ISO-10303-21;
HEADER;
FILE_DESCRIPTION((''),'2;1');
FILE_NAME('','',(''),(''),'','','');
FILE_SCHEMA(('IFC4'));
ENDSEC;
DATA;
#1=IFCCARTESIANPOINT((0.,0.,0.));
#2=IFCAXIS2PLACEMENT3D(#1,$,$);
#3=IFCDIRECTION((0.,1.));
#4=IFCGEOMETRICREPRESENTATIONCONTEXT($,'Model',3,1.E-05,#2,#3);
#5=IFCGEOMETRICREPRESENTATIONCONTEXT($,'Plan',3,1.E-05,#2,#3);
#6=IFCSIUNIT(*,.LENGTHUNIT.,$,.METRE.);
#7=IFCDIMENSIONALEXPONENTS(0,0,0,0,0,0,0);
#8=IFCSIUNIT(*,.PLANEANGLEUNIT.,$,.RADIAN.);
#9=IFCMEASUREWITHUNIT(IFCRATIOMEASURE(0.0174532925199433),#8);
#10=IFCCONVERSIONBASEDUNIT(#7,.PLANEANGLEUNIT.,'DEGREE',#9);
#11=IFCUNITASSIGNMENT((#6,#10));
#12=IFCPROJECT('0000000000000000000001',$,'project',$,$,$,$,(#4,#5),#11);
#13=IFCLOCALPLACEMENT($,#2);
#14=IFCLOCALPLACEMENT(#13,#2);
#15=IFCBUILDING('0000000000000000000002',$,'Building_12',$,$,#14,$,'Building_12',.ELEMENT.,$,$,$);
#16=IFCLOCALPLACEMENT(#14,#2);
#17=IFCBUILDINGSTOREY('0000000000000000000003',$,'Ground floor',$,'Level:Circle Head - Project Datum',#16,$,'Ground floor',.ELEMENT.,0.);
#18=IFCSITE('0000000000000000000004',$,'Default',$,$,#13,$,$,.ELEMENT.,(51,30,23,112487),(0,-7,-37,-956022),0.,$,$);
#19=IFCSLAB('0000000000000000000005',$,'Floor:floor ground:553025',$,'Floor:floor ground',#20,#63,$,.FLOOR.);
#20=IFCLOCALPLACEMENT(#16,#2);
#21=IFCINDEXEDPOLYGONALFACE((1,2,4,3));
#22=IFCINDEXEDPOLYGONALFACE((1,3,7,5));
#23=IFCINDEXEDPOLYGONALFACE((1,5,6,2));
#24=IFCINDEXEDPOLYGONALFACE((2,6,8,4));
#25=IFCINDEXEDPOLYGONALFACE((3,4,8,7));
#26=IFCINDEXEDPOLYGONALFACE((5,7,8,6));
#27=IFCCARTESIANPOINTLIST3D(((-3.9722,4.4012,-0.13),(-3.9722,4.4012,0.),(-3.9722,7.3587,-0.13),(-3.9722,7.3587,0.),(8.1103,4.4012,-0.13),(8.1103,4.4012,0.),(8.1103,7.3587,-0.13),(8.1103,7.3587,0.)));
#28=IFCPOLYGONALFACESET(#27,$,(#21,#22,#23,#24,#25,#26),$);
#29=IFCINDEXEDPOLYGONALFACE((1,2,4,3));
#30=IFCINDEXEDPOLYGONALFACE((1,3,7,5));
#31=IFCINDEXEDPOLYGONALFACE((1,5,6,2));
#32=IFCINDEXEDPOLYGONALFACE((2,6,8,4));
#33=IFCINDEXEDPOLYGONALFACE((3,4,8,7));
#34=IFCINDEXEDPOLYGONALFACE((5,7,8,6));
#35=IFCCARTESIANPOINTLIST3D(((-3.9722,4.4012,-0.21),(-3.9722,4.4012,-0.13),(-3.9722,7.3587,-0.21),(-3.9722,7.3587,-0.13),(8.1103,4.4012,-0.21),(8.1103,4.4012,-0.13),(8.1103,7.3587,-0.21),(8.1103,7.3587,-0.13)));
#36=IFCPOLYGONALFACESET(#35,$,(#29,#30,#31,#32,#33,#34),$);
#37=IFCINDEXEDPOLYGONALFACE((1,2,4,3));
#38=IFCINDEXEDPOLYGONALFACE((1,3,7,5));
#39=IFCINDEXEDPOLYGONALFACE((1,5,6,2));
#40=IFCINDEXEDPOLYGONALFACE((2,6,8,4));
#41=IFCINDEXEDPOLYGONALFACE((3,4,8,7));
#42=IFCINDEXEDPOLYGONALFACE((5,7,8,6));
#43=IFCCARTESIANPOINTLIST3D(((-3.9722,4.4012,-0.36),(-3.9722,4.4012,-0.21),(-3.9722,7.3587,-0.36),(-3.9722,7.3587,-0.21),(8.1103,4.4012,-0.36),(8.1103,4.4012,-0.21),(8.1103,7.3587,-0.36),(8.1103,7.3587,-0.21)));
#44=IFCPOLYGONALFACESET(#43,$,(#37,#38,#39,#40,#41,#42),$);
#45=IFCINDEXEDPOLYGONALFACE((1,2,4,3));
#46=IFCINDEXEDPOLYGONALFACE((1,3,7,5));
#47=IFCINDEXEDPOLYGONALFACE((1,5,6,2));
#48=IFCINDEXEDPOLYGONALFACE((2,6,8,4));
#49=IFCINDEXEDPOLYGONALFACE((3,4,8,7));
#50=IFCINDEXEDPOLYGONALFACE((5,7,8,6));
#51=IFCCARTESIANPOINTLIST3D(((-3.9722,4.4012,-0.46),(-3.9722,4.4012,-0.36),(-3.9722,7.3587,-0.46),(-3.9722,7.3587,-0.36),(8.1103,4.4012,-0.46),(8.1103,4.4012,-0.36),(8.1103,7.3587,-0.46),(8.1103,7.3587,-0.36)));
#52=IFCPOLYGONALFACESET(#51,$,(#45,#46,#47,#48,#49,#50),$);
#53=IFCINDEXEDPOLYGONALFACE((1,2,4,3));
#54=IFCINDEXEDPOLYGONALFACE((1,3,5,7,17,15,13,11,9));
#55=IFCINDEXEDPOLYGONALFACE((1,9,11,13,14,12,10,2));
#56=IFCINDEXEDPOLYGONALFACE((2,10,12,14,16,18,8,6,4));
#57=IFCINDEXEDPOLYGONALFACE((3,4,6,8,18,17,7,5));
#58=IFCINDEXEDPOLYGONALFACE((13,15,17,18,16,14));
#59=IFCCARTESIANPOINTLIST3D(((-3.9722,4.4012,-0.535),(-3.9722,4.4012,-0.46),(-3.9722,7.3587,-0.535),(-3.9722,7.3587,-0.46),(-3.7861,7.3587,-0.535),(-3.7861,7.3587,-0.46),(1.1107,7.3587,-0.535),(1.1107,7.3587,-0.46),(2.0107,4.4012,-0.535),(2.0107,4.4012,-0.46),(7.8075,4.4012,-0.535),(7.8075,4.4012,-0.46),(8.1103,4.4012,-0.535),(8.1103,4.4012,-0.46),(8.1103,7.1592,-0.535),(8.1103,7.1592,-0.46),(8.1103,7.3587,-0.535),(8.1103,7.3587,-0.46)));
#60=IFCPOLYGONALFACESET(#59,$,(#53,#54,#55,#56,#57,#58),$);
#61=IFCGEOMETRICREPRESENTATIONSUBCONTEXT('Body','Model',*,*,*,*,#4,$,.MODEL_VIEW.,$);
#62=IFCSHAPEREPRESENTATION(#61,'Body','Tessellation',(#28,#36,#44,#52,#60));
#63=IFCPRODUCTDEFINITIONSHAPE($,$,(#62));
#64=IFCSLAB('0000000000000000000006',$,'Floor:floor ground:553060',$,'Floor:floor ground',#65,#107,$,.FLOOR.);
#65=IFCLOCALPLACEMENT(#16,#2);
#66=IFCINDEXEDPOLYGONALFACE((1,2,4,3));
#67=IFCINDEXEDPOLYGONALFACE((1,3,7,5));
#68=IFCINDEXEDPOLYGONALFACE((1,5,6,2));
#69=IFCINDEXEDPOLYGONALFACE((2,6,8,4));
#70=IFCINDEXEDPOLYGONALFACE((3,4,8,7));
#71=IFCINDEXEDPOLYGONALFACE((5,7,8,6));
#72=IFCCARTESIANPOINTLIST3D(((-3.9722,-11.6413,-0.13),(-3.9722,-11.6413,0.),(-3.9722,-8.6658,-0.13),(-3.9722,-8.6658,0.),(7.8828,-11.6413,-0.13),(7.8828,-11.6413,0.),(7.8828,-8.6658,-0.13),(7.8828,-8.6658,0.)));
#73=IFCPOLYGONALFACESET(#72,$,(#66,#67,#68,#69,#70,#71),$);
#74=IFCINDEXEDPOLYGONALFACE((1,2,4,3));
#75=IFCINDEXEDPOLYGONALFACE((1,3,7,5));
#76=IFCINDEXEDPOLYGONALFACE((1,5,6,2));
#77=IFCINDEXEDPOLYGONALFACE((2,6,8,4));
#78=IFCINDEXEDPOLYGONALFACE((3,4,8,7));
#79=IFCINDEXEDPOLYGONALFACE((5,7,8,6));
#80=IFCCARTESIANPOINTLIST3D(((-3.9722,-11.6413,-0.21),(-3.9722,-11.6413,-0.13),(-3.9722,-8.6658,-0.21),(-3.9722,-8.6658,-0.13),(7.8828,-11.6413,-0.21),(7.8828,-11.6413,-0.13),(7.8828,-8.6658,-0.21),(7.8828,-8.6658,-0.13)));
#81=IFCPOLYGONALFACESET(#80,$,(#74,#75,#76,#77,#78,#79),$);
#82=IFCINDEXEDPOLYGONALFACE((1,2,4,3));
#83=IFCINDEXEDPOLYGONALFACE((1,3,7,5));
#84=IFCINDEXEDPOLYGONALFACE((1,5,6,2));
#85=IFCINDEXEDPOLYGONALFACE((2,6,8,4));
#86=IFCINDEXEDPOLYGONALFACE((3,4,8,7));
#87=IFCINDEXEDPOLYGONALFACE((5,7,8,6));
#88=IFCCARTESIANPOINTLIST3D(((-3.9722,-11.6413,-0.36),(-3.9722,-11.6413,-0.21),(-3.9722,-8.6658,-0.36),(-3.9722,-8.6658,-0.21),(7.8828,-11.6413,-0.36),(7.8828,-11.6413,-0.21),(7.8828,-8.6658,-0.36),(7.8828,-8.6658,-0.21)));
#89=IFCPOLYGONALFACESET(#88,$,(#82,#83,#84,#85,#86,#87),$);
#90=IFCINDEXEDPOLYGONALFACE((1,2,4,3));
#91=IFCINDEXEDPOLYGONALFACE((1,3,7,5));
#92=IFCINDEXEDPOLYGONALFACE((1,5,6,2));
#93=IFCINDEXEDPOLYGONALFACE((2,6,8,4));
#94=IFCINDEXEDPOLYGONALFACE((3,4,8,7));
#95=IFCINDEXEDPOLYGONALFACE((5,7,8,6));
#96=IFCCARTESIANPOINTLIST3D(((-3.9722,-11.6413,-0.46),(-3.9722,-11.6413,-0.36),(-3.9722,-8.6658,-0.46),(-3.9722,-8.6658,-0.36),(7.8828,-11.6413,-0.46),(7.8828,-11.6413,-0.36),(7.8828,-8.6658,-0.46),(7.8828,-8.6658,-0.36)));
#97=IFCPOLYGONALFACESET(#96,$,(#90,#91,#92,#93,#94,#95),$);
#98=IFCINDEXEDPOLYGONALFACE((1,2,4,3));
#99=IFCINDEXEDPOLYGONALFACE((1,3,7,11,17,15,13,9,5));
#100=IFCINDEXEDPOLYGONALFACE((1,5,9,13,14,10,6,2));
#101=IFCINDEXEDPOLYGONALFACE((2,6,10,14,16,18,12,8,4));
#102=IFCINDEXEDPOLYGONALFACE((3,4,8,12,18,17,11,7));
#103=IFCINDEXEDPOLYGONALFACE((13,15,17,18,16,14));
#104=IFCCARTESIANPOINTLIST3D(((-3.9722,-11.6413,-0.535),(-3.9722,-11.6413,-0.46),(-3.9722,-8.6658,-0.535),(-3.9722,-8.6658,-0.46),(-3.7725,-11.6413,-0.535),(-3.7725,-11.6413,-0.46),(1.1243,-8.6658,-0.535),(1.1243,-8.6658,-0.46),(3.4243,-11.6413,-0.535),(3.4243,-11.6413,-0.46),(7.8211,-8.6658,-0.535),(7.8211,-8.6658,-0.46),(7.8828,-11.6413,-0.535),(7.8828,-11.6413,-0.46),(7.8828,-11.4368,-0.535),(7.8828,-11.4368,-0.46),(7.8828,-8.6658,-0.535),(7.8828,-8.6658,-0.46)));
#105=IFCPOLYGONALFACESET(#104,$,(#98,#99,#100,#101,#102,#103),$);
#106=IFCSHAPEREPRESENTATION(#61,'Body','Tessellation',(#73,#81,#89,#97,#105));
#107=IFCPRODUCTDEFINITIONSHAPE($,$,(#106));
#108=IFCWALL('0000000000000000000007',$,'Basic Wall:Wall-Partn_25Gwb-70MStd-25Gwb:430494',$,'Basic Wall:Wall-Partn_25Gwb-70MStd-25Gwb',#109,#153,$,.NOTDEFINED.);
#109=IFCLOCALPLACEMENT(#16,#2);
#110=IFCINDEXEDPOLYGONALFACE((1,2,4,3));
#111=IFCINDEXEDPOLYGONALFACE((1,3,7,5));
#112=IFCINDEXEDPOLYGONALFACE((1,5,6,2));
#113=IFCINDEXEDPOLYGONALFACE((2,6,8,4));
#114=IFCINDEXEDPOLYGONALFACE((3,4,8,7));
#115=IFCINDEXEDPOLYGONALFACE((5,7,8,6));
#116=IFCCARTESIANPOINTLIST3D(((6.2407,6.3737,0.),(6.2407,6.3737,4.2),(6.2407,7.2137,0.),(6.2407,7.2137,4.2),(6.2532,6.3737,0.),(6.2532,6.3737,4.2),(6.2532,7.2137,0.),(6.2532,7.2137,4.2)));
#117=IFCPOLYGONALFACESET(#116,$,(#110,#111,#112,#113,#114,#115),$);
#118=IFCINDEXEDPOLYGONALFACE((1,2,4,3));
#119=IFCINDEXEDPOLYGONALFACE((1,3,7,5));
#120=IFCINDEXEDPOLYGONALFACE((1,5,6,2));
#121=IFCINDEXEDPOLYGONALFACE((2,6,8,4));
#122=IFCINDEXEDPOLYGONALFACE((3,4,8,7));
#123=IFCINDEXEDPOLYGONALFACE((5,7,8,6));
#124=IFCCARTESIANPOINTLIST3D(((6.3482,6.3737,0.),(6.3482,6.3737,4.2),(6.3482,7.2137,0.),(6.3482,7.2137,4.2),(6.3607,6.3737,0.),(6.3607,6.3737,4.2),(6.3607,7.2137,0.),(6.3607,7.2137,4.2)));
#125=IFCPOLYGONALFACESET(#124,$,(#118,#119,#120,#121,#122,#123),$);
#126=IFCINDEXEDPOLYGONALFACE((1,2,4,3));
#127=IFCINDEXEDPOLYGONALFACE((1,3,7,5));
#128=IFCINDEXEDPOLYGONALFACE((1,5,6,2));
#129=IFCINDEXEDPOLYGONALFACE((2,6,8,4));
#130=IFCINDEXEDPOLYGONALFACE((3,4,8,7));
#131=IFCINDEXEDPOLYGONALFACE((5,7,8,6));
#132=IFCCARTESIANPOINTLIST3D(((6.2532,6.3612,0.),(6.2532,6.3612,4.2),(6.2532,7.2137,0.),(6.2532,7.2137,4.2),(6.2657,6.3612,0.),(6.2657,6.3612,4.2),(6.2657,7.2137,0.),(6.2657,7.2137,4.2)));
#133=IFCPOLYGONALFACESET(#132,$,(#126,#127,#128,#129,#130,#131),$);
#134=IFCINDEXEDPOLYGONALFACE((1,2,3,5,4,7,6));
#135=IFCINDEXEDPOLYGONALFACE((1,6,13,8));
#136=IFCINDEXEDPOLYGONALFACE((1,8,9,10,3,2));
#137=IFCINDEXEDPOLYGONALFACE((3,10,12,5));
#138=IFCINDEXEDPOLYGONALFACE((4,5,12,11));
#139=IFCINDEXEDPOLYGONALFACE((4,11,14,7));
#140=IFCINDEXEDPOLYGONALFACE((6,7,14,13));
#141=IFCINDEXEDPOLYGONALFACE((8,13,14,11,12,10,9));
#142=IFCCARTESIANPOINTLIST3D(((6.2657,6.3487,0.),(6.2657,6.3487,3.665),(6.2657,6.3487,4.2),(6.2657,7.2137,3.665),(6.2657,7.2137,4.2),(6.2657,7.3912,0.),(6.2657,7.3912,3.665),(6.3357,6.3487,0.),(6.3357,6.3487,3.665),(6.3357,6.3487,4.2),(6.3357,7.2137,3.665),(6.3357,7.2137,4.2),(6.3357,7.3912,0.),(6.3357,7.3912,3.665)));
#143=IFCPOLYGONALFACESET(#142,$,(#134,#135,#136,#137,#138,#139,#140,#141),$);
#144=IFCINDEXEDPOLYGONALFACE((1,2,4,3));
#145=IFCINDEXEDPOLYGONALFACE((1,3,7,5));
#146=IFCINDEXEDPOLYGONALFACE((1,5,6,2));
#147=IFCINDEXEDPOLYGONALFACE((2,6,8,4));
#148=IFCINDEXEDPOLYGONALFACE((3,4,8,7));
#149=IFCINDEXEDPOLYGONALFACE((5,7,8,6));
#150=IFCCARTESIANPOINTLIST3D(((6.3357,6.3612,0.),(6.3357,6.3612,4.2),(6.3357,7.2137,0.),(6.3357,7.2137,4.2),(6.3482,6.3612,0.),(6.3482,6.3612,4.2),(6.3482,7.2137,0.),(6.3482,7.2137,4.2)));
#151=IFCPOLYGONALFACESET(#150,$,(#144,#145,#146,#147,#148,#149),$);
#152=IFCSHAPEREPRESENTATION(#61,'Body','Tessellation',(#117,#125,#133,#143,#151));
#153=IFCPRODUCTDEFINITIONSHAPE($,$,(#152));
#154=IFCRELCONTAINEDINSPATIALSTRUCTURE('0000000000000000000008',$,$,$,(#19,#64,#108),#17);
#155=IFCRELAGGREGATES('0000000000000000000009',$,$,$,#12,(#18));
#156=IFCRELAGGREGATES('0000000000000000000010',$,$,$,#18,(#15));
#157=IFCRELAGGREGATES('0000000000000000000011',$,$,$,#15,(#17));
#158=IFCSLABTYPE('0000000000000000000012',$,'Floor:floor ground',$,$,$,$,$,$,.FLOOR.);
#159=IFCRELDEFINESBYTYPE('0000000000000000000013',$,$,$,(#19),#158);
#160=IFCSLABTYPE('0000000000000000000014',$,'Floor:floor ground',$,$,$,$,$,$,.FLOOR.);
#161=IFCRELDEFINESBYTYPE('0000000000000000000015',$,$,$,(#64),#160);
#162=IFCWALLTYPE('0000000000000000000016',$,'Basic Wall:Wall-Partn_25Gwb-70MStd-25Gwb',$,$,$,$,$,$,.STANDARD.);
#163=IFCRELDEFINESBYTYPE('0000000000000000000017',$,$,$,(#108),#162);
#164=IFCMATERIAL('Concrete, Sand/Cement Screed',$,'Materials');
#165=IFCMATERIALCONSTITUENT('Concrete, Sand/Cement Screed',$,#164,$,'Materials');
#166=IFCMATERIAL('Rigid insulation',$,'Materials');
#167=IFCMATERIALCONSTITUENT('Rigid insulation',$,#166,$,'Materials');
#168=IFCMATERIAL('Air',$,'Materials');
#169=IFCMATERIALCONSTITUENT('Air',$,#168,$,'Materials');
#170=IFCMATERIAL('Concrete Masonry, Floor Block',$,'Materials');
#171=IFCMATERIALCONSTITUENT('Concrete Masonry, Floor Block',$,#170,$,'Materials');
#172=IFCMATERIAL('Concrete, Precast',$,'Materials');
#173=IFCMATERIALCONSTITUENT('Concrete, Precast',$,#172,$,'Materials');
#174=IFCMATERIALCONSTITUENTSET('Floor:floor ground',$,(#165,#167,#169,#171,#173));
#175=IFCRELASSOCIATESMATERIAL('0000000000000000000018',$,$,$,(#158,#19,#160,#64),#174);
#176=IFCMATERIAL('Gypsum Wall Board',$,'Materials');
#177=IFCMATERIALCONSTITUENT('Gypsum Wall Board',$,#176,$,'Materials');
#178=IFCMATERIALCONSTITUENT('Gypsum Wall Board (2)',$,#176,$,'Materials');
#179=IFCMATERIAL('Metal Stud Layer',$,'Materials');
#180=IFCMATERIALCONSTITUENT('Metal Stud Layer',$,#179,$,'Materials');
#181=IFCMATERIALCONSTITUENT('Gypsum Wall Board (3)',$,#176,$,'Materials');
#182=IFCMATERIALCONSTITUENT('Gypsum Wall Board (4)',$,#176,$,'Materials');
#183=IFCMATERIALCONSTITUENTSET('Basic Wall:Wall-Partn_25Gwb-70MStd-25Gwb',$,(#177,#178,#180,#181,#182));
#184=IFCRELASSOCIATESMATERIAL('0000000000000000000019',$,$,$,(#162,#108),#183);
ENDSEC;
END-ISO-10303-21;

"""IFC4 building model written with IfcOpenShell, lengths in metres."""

from ifc_helpers import new_model, entity, si_unit, converted_unit, direction, frame, origin, place, context, subcontext, project, spatial, indexed_curve, outline, extrude, material, constituent, constituent_set, type_object, element, save


model = new_model("IFC4")

# Units and contexts
model_context = context("Model", 3, precision=1e-05, world=origin(), true_north=direction((0.0, 1.0)))
plan_context = context("Plan", 3, precision=1e-05, world=origin(), true_north=direction((0.0, 1.0)))
body_context = subcontext(model_context, "Body", "Model", "MODEL_VIEW")
ifc_project = project(units=[si_unit("LENGTHUNIT", "METRE"), converted_unit("PLANEANGLEUNIT", "DEGREE", entity("IfcRatioMeasure", 0.0174532925199433), si_unit("PLANEANGLEUNIT", "RADIAN"), dimensions=[0, 0, 0, 0, 0, 0, 0])], contexts=[model_context, plan_context])

# Site, building, storey
site_placement = place(None, origin())
site = spatial("IfcSite", under=ifc_project, at=site_placement, Name="Default", CompositionType="ELEMENT", RefLatitude=(51, 30, 23, 112487), RefLongitude=(0, -7, -37, -956022), RefElevation=0.0)
building_placement = place(site_placement, origin())
building = spatial("IfcBuilding", under=site, at=building_placement, Name="Building_12", LongName="Building_12", CompositionType="ELEMENT")
storey_placement = place(building_placement, origin())
storey = spatial("IfcBuildingStorey", under=building, at=storey_placement, Name="Ground floor", ObjectType="Level:Circle Head - Project Datum", LongName="Ground floor", CompositionType="ELEMENT", Elevation=0.0)

# Slabs
ifc_material_1 = material(Name="Concrete, Sand/Cement Screed", Category="Materials")
ifc_constituent_1 = constituent(ifc_material_1, Name="Concrete, Sand/Cement Screed", Category="Materials")
ifc_material_2 = material(Name="Rigid insulation", Category="Materials")
ifc_constituent_2 = constituent(ifc_material_2, Name="Rigid insulation", Category="Materials")
ifc_material_3 = material(Name="Air", Category="Materials")
ifc_constituent_3 = constituent(ifc_material_3, Name="Air", Category="Materials")
ifc_material_4 = material(Name="Concrete Masonry, Floor Block", Category="Materials")
ifc_constituent_4 = constituent(ifc_material_4, Name="Concrete Masonry, Floor Block", Category="Materials")
ifc_material_5 = material(Name="Concrete, Precast", Category="Materials")
ifc_constituent_5 = constituent(ifc_material_5, Name="Concrete, Precast", Category="Materials")
ifc_constituent_set_1 = constituent_set(constituents=[ifc_constituent_1, ifc_constituent_2, ifc_constituent_3, ifc_constituent_4, ifc_constituent_5], Name="Floor:floor ground")
slab_type_1 = type_object("IfcSlabType", Name="Floor:floor ground", PredefinedType="FLOOR", material=ifc_constituent_set_1)
slab_1_placement = place(storey_placement, origin())
element("IfcSlab", 1, at=slab_1_placement, inside=storey, type_object=slab_type_1, material=ifc_constituent_set_1, Name="Floor:floor ground:553025", ObjectType="Floor:floor ground", PredefinedType="FLOOR", context=body_context, shape_type="SweptSolid", body=[
    extrude(outline(indexed_curve([(-1.4787, -6.0412), (1.4787, -6.0412), (1.4787, 6.0412), (-1.4787, 6.0412), (-1.4787, -6.0412)], self_intersect=False)), frame((2.0691, 5.8799, -0.13), z_axis=(0.0, 0.0, 1.0), x_axis=(0.0, -1.0, 0.0)), (0.0, 0.0, 1.0), 0.13),
    extrude(outline(indexed_curve([(-1.4787, -6.0412), (1.4787, -6.0412), (1.4787, 6.0412), (-1.4787, 6.0412), (-1.4787, -6.0412)], self_intersect=False)), frame((2.0691, 5.8799, -0.21), z_axis=(0.0, 0.0, 1.0), x_axis=(0.0, -1.0, 0.0)), (0.0, 0.0, 1.0), 0.08),
    extrude(outline(indexed_curve([(-1.4787, -6.0412), (1.4787, -6.0412), (1.4787, 6.0412), (-1.4787, 6.0412), (-1.4787, -6.0412)], self_intersect=False)), frame((2.0691, 5.8799, -0.36), z_axis=(0.0, 0.0, 1.0), x_axis=(0.0, -1.0, 0.0)), (0.0, 0.0, 1.0), 0.15),
    extrude(outline(indexed_curve([(-1.4787, -6.0412), (1.4787, -6.0412), (1.4787, 6.0412), (-1.4787, 6.0412), (-1.4787, -6.0412)], self_intersect=False)), frame((2.0691, 5.8799, -0.46), z_axis=(0.0, 0.0, 1.0), x_axis=(0.0, -1.0, 0.0)), (0.0, 0.0, 1.0), 0.1),
    extrude(outline(indexed_curve([(-1.3366, -6.5866), (1.6209, -6.5866), (1.6209, -0.6037), (1.6209, 5.1931), (1.6209, 5.4959), (-1.1371, 5.4959), (-1.3366, 5.4959), (-1.3366, -1.5037), (-1.3366, -6.4005), (-1.3366, -6.5866)], self_intersect=False)), frame((2.6144, 6.0221, -0.535), z_axis=(0.0, 0.0, 1.0), x_axis=(0.0, -1.0, 0.0)), (0.0, 0.0, 1.0), 0.075),
])
slab_type_2 = type_object("IfcSlabType", Name="Floor:floor ground", PredefinedType="FLOOR", material=ifc_constituent_set_1)
slab_2_placement = place(storey_placement, origin())
element("IfcSlab", 2, at=slab_2_placement, inside=storey, type_object=slab_type_2, material=ifc_constituent_set_1, Name="Floor:floor ground:553060", ObjectType="Floor:floor ground", PredefinedType="FLOOR", context=body_context, shape_type="SweptSolid", body=[
    extrude(outline(indexed_curve([(-1.4877, -5.9275), (1.4877, -5.9275), (1.4877, 5.9275), (-1.4877, 5.9275), (-1.4877, -5.9275)], self_intersect=False)), frame((1.9553, -10.1536, -0.13), z_axis=(0.0, 0.0, 1.0), x_axis=(0.0, -1.0, 0.0)), (0.0, 0.0, 1.0), 0.13),
    extrude(outline(indexed_curve([(-1.4877, -5.9275), (1.4877, -5.9275), (1.4877, 5.9275), (-1.4877, 5.9275), (-1.4877, -5.9275)], self_intersect=False)), frame((1.9553, -10.1536, -0.21), z_axis=(0.0, 0.0, 1.0), x_axis=(0.0, -1.0, 0.0)), (0.0, 0.0, 1.0), 0.08),
    extrude(outline(indexed_curve([(-1.4877, -5.9275), (1.4877, -5.9275), (1.4877, 5.9275), (-1.4877, 5.9275), (-1.4877, -5.9275)], self_intersect=False)), frame((1.9553, -10.1536, -0.36), z_axis=(0.0, 0.0, 1.0), x_axis=(0.0, -1.0, 0.0)), (0.0, 0.0, 1.0), 0.15),
    extrude(outline(indexed_curve([(-1.4877, -5.9275), (1.4877, -5.9275), (1.4877, 5.9275), (-1.4877, 5.9275), (-1.4877, -5.9275)], self_intersect=False)), frame((1.9553, -10.1536, -0.46), z_axis=(0.0, 0.0, 1.0), x_axis=(0.0, -1.0, 0.0)), (0.0, 0.0, 1.0), 0.1),
    extrude(outline(indexed_curve([(-1.6303, -6.6723), (1.3452, -6.6723), (1.3452, -6.4726), (1.3452, 0.7242), (1.3452, 5.1827), (1.1406, 5.1827), (-1.6303, 5.1827), (-1.6303, 5.121), (-1.6303, -1.5758), (-1.6303, -6.6723)], self_intersect=False)), frame((2.7001, -10.2962, -0.535), z_axis=(0.0, 0.0, 1.0), x_axis=(0.0, -1.0, 0.0)), (0.0, 0.0, 1.0), 0.075),
])

# Wall
ifc_material_6 = material(Name="Gypsum Wall Board", Category="Materials")
ifc_constituent_6 = constituent(ifc_material_6, Name="Gypsum Wall Board", Category="Materials")
ifc_constituent_7 = constituent(ifc_material_6, Name="Gypsum Wall Board (2)", Category="Materials")
ifc_material_7 = material(Name="Metal Stud Layer", Category="Materials")
ifc_constituent_8 = constituent(ifc_material_7, Name="Metal Stud Layer", Category="Materials")
ifc_constituent_9 = constituent(ifc_material_6, Name="Gypsum Wall Board (3)", Category="Materials")
ifc_constituent_10 = constituent(ifc_material_6, Name="Gypsum Wall Board (4)", Category="Materials")
ifc_constituent_set_2 = constituent_set(constituents=[ifc_constituent_6, ifc_constituent_7, ifc_constituent_8, ifc_constituent_9, ifc_constituent_10], Name="Basic Wall:Wall-Partn_25Gwb-70MStd-25Gwb")
wall_type_1 = type_object("IfcWallType", Name="Basic Wall:Wall-Partn_25Gwb-70MStd-25Gwb", PredefinedType="STANDARD", material=ifc_constituent_set_2)
wall_1_placement = place(storey_placement, frame((6.3007, 7.2137, 0.0), z_axis=(0.0, 0.0, 1.0), x_axis=(0.0, -1.0, 0.0)))
element("IfcWall", 3, at=wall_1_placement, inside=storey, type_object=wall_type_1, material=ifc_constituent_set_2, Name="Basic Wall:Wall-Partn_25Gwb-70MStd-25Gwb:430494", ObjectType="Basic Wall:Wall-Partn_25Gwb-70MStd-25Gwb", PredefinedType="NOTDEFINED", context=body_context, shape_type="SweptSolid", body=[
    extrude(outline(indexed_curve([(-0.0062, -0.42), (0.0062, -0.42), (0.0063, 0.42), (-0.0062, 0.42), (-0.0062, -0.42)], self_intersect=False)), frame((0.42, -0.0538, 0.0), z_axis=(0.0, 0.0, 1.0), x_axis=(0.0, 1.0, 0.0)), (0.0, 0.0, 1.0), 4.2),
    extrude(outline(indexed_curve([(-0.0063, -0.42), (0.0062, -0.42), (0.0063, 0.42), (-0.0062, 0.42), (-0.0063, -0.42)], self_intersect=False)), frame((0.42, 0.0538, 0.0), z_axis=(0.0, 0.0, 1.0), x_axis=(0.0, -1.0, 0.0)), (0.0, 0.0, 1.0), 4.2),
    extrude(outline(indexed_curve([(-0.0063, -0.4263), (0.0062, -0.4263), (0.0063, 0.4262), (-0.0062, 0.4262), (-0.0063, -0.4263)], self_intersect=False)), frame((0.4263, -0.0412, 0.0), z_axis=(0.0, 0.0, 1.0), x_axis=(0.0, -1.0, 0.0)), (0.0, 0.0, 1.0), 4.2),
    extrude(outline(indexed_curve([(-2.7707, -0.4975), (0.8943, -0.4975), (0.8943, -0.32), (1.4293, -0.32), (1.4293, 0.545), (0.8943, 0.545), (-2.7707, 0.545), (-2.7707, -0.4975)], self_intersect=False)), frame((0.32, -0.035, 2.7707), z_axis=(0.0, 1.0, 0.0), x_axis=(0.0, 0.0, 1.0)), (0.0, 0.0, 1.0), 0.07),
    extrude(outline(indexed_curve([(-0.0063, -0.4263), (0.0062, -0.4263), (0.0063, 0.4262), (-0.0062, 0.4262), (-0.0063, -0.4263)], self_intersect=False)), frame((0.4263, 0.0412, 0.0), z_axis=(0.0, 0.0, 1.0), x_axis=(0.0, -1.0, 0.0)), (0.0, 0.0, 1.0), 4.2),
])

save(model, "model.ifc")
